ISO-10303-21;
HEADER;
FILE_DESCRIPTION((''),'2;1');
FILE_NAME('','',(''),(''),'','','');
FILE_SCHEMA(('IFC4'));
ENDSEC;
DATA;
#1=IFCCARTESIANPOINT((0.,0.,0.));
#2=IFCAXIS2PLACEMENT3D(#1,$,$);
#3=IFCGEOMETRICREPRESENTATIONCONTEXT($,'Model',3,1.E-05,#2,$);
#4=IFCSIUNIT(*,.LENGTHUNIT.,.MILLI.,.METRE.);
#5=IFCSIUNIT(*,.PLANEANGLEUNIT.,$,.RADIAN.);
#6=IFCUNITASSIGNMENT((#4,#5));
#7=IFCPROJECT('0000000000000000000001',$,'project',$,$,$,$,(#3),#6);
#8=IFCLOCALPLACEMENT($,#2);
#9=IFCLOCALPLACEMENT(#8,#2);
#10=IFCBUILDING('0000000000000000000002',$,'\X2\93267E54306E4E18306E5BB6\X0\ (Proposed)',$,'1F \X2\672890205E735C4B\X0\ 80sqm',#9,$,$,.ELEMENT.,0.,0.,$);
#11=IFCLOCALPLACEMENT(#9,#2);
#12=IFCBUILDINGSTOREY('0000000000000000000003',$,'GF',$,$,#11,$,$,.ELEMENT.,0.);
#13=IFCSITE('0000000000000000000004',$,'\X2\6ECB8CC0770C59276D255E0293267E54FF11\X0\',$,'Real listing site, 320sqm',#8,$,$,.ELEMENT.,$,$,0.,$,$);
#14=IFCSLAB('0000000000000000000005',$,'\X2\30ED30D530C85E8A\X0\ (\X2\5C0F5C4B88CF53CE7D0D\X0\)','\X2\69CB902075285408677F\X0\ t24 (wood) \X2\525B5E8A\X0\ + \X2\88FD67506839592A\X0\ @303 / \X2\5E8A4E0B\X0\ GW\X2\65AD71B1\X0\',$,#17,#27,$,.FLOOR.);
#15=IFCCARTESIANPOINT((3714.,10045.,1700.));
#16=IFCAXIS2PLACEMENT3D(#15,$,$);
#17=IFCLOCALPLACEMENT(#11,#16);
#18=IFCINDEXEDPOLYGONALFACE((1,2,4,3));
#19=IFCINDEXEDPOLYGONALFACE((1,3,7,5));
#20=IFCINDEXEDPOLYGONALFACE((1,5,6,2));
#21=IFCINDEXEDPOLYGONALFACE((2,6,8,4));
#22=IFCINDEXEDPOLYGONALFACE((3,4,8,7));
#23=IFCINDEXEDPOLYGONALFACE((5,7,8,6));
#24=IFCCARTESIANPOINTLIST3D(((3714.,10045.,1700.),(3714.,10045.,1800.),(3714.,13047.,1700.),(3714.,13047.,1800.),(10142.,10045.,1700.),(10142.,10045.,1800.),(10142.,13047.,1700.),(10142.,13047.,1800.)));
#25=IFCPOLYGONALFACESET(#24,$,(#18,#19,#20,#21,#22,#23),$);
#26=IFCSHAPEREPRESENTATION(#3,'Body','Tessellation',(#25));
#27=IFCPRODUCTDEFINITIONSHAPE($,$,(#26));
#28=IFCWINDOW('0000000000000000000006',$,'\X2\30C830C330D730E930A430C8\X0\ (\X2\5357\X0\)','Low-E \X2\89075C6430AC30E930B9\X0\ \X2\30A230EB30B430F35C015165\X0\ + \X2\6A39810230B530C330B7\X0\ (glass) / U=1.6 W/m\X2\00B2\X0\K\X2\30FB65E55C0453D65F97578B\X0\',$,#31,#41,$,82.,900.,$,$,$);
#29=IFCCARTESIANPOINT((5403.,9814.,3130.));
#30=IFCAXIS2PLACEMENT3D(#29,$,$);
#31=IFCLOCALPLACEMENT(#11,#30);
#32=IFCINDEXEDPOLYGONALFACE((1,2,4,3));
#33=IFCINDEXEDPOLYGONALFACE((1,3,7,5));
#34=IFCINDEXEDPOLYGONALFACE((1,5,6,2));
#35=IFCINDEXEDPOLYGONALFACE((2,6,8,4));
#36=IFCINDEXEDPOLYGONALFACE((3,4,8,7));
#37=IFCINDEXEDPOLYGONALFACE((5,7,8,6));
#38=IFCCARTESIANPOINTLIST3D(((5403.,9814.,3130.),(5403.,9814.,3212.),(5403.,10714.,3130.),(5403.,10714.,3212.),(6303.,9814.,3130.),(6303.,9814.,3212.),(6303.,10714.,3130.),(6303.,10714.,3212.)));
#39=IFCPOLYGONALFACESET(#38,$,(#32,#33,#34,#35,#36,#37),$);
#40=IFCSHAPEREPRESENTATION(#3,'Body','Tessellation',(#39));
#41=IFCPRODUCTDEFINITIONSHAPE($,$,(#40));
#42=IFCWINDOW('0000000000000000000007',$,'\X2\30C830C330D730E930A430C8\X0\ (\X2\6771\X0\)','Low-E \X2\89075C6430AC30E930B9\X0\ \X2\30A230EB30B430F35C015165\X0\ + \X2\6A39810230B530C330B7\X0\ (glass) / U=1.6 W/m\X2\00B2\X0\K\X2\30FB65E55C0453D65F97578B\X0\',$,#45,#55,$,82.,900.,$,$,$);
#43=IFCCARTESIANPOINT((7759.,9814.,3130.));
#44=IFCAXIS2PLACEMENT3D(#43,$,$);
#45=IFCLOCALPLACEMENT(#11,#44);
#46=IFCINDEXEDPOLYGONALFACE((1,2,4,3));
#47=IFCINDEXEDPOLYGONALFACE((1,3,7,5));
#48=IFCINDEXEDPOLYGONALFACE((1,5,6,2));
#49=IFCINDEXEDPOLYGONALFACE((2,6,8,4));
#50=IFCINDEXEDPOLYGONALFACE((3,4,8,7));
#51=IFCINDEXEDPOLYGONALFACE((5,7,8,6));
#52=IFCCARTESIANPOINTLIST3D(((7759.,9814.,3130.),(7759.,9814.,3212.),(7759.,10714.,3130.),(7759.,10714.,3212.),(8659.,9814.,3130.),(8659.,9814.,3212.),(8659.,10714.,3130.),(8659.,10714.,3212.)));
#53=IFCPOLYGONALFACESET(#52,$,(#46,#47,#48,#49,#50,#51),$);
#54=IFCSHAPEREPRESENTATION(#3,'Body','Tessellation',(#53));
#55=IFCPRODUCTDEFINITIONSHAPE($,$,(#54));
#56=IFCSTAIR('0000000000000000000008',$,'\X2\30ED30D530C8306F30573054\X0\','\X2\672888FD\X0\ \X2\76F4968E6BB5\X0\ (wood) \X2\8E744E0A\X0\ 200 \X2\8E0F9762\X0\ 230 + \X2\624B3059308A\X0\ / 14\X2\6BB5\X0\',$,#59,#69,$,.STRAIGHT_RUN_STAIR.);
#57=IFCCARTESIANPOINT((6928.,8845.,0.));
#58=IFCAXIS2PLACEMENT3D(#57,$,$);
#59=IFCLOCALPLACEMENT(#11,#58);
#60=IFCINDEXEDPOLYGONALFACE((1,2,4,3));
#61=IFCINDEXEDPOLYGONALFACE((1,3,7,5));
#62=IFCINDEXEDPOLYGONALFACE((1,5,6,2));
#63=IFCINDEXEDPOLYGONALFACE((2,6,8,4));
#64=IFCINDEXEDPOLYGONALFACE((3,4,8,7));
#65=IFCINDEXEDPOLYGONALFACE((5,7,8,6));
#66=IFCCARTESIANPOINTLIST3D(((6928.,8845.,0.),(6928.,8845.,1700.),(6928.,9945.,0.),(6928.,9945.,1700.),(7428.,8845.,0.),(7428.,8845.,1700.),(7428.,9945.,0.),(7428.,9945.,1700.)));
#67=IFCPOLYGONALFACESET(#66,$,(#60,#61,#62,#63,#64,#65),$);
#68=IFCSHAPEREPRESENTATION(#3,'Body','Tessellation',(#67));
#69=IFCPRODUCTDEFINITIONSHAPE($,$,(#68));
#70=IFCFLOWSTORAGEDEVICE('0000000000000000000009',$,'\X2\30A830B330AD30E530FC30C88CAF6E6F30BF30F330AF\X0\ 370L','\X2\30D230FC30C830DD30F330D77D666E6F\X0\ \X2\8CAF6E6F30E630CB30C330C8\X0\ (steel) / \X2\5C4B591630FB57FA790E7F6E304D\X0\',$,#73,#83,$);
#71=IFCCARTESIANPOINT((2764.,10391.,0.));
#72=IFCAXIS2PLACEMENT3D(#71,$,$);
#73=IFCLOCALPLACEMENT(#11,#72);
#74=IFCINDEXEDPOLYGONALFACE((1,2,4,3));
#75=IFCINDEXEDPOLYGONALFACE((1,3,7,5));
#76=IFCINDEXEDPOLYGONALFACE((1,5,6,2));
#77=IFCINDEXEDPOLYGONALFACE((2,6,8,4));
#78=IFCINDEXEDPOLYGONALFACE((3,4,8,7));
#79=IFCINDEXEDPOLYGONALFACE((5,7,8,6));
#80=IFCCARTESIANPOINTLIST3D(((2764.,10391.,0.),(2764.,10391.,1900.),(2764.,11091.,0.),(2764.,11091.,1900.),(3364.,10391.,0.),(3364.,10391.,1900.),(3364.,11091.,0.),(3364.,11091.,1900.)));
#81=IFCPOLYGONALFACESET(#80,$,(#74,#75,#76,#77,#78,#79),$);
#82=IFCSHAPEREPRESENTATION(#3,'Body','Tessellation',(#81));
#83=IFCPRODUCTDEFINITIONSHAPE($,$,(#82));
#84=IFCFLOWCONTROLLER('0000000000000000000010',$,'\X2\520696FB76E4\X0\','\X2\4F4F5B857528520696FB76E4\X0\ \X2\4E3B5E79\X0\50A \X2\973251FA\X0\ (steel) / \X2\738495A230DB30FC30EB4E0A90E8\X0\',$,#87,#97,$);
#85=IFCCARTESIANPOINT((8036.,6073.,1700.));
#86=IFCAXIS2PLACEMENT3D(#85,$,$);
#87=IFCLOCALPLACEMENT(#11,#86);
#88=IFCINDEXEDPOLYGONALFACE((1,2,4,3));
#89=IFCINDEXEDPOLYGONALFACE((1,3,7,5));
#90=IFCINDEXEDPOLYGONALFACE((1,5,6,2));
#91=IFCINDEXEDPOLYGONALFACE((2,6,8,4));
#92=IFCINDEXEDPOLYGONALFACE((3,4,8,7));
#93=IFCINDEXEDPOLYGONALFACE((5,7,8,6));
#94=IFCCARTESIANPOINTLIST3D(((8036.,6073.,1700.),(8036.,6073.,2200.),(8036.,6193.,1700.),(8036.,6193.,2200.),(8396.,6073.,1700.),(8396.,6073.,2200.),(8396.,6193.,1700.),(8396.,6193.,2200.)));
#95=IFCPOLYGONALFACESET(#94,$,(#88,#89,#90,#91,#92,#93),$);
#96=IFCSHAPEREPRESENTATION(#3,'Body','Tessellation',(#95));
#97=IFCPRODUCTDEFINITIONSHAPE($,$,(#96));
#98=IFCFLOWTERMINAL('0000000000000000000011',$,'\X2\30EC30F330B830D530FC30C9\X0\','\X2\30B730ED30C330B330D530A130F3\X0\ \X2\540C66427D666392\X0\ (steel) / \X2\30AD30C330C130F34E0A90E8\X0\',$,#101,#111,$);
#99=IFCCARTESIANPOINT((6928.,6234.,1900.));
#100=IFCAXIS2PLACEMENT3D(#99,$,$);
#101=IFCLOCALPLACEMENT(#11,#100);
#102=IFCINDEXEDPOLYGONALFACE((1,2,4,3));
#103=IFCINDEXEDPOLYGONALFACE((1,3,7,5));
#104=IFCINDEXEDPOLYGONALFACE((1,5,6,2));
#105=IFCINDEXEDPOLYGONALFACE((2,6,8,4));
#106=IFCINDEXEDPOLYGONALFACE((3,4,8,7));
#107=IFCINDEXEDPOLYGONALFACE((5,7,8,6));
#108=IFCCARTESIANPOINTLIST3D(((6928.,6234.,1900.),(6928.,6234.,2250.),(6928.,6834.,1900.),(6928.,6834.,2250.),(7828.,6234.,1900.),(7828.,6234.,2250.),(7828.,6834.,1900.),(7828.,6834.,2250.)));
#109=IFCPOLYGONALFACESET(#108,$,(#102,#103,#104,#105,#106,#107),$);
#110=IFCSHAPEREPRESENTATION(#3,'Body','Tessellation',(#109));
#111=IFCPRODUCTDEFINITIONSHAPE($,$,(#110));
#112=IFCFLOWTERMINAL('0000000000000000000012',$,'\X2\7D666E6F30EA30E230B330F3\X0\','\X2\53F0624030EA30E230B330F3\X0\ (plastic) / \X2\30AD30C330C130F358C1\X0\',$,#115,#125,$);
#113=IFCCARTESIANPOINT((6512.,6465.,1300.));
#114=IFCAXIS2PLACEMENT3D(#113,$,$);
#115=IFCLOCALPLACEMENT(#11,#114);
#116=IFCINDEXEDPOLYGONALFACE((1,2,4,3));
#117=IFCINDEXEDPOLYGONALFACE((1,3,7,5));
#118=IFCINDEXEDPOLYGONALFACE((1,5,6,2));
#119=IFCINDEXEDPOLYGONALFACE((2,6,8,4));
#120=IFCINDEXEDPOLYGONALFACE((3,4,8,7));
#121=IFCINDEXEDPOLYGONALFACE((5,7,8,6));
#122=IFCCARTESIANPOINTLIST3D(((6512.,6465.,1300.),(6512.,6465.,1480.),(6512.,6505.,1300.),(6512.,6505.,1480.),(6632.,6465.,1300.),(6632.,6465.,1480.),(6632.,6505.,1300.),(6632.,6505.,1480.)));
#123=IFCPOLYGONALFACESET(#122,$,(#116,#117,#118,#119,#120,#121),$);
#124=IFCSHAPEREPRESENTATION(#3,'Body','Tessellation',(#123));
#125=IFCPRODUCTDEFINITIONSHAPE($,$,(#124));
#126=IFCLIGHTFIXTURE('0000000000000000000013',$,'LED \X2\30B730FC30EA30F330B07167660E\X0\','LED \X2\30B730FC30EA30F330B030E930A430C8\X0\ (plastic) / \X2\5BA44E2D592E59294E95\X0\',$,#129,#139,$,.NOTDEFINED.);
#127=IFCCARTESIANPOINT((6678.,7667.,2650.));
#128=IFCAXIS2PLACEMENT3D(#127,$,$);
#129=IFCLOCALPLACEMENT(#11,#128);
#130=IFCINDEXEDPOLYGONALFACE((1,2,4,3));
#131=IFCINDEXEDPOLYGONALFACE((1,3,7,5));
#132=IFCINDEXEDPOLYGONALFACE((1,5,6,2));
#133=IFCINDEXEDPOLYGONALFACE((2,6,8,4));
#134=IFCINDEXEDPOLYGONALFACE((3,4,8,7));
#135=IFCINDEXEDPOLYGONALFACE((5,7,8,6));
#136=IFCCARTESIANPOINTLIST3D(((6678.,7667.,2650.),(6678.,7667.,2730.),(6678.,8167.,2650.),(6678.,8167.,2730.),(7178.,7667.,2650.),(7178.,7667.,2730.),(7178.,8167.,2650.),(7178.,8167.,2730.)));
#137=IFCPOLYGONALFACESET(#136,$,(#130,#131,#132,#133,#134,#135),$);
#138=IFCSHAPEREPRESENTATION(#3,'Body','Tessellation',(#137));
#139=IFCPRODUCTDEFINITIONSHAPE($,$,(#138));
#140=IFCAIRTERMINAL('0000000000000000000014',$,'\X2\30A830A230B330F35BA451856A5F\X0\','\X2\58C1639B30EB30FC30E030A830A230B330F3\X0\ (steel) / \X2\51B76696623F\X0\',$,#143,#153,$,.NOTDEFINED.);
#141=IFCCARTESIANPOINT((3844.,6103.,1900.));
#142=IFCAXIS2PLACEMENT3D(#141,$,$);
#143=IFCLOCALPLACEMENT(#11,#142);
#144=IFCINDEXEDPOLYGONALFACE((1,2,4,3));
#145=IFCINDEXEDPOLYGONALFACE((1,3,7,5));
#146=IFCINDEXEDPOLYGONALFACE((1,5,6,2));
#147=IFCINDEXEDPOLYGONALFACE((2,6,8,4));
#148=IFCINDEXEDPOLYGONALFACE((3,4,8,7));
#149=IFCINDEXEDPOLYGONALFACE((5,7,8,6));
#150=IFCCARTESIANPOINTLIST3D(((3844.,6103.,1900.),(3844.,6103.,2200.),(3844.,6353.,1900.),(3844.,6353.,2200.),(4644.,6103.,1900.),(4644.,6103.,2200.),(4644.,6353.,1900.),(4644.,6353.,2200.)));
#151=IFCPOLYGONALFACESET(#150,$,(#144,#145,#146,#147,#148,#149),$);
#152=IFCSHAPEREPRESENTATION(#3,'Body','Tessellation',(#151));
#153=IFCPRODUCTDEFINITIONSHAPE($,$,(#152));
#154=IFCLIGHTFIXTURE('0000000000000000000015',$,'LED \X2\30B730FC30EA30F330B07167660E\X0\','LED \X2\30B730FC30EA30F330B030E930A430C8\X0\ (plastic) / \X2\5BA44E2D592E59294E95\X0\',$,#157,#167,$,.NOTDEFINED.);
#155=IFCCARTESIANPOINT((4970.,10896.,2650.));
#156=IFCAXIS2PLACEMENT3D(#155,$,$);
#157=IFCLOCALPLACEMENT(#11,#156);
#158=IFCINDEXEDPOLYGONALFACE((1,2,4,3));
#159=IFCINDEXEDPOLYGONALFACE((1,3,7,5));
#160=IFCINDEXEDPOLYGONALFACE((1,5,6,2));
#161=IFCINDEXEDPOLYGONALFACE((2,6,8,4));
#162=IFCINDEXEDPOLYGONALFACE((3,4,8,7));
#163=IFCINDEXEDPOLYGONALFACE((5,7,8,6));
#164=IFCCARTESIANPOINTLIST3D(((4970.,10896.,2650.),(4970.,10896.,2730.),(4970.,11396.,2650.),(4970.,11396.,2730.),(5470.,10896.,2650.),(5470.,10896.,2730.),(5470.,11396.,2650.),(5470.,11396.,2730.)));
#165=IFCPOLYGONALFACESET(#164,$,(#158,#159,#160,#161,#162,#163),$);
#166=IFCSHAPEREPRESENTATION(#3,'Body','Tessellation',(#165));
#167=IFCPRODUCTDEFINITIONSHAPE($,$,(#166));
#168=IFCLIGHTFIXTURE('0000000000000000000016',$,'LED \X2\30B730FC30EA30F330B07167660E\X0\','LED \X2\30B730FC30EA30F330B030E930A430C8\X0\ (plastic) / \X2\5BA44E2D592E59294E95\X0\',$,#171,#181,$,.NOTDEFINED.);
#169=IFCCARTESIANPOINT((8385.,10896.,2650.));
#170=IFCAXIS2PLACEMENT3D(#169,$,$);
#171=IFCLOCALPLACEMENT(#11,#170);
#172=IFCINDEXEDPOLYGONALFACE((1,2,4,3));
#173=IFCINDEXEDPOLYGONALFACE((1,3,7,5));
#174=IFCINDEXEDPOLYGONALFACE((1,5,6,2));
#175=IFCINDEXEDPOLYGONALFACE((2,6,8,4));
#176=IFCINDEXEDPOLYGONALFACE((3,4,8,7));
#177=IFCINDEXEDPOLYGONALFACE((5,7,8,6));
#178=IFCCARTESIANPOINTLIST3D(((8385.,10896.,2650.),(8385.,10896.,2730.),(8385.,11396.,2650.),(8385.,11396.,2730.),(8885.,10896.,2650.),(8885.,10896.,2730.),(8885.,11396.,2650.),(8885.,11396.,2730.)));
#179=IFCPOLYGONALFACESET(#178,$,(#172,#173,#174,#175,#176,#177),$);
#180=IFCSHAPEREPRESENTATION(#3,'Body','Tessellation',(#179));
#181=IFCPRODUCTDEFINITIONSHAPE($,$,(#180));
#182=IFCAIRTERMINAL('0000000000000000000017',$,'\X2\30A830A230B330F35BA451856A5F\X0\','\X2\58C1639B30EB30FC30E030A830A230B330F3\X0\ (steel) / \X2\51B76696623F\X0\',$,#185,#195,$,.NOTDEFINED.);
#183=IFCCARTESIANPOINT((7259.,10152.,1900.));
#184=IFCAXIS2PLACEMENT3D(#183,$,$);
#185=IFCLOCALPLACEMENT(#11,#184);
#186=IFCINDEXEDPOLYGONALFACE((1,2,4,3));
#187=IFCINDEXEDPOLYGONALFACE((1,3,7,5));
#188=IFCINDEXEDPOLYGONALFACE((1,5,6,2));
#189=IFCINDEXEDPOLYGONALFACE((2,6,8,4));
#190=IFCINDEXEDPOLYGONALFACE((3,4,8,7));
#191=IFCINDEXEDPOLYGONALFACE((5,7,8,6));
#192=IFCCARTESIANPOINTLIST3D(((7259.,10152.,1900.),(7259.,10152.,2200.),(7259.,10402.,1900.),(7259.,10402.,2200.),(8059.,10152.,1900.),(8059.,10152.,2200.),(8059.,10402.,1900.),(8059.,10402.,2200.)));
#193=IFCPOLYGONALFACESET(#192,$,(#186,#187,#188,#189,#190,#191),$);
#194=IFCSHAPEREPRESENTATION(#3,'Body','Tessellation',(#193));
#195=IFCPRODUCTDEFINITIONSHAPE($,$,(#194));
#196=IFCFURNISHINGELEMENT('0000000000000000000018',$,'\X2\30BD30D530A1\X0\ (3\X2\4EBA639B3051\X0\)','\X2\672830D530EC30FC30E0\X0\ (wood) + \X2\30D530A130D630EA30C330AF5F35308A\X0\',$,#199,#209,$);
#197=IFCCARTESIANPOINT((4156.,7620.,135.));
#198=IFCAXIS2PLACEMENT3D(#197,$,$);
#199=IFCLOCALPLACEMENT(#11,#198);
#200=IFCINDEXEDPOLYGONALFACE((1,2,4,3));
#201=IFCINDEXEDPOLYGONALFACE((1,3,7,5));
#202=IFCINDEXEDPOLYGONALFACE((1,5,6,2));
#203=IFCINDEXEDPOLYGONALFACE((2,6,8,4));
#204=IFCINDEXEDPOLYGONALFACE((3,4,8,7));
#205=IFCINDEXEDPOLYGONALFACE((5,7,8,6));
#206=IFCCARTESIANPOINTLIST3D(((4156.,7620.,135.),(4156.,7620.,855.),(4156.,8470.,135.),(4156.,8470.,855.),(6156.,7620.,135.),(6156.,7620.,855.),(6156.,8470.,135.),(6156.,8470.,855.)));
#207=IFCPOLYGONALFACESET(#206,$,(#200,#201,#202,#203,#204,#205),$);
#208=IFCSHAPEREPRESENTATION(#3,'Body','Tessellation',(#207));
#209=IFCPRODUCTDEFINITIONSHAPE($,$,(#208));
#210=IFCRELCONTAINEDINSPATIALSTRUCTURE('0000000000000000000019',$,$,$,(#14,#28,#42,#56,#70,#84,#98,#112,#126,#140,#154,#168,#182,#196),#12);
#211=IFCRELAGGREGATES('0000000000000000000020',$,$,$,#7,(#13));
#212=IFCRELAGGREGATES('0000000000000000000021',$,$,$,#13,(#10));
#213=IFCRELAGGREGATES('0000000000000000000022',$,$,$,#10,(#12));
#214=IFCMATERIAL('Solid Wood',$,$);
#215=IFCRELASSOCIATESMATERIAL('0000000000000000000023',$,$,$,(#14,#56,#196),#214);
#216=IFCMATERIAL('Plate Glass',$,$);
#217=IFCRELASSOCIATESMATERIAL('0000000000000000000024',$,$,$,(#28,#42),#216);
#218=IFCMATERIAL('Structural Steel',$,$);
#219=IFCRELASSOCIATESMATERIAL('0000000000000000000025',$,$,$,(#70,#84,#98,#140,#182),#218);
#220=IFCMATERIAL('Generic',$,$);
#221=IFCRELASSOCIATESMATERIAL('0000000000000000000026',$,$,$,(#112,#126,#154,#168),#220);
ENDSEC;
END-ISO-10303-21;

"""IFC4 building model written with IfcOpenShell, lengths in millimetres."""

from ifc_helpers import new_model, si_unit, frame, frame_2d, origin, place, context, project, spatial, rectangle, extrude, material, element, save


model = new_model("IFC4")

# Units and contexts
model_context = context("Model", 3, precision=1e-05, world=origin())
ifc_project = project(units=[si_unit("LENGTHUNIT", "METRE", prefix="MILLI"), si_unit("PLANEANGLEUNIT", "RADIAN")], contexts=[model_context])

# Site, building, storey
site_placement = place(None, origin())
site = spatial("IfcSite", under=ifc_project, at=site_placement, Name="滋賀県大津市錦織１", ObjectType="Real listing site, 320sqm", CompositionType="ELEMENT", RefElevation=0.0)
building_placement = place(site_placement, origin())
building = spatial("IfcBuilding", under=site, at=building_placement, Name="錦織の丘の家 (Proposed)", ObjectType="1F 木造平屋 80sqm", CompositionType="ELEMENT", ElevationOfRefHeight=0.0, ElevationOfTerrain=0.0)
storey_placement = place(building_placement, origin())
storey = spatial("IfcBuildingStorey", under=building, at=storey_placement, Name="GF", CompositionType="ELEMENT", Elevation=0.0)

# Shared definitions
ifc_material_1 = material(Name="Solid Wood")

# Slab
slab_placement = place(storey_placement, frame((3714.0, 10045.0, 1700.0)))
element("IfcSlab", 1, at=slab_placement, inside=storey, material=ifc_material_1, Name="ロフト床 (小屋裏収納)", Description="構造用合板 t24 (wood) 剛床 + 製材根太 @303 / 床下 GW断熱", PredefinedType="FLOOR", context=model_context, shape_type="SweptSolid", body=[
    extrude(rectangle(XDim=6428.0, YDim=3002.0, at=frame_2d((3214.0, 1501.0))), frame((3714.0, 10045.0, 1700.0)), (0.0, 0.0, 1.0), 100.0),
])

# Windows
ifc_material_2 = material(Name="Plate Glass")
window_1_placement = place(storey_placement, frame((5403.0, 9814.0, 3130.0)))
element("IfcWindow", 2, at=window_1_placement, inside=storey, material=ifc_material_2, Name="トップライト (南)", Description="Low-E 複層ガラス アルゴン封入 + 樹脂サッシ (glass) / U=1.6 W/m²K・日射取得型", OverallHeight=82.0, OverallWidth=900.0, context=model_context, shape_type="SweptSolid", body=[
    extrude(rectangle(XDim=900.0, YDim=900.0, at=frame_2d((450.0, 450.0))), frame((5403.0, 9814.0, 3130.0)), (0.0, 0.0, 1.0), 82.0),
])
window_2_placement = place(storey_placement, frame((7759.0, 9814.0, 3130.0)))
element("IfcWindow", 3, at=window_2_placement, inside=storey, material=ifc_material_2, Name="トップライト (東)", Description="Low-E 複層ガラス アルゴン封入 + 樹脂サッシ (glass) / U=1.6 W/m²K・日射取得型", OverallHeight=82.0, OverallWidth=900.0, context=model_context, shape_type="SweptSolid", body=[
    extrude(rectangle(XDim=900.0, YDim=900.0, at=frame_2d((450.0, 450.0))), frame((7759.0, 9814.0, 3130.0)), (0.0, 0.0, 1.0), 82.0),
])

# Stair
stair_placement = place(storey_placement, frame((6928.0, 8845.0, 0.0)))
element("IfcStair", 4, at=stair_placement, inside=storey, material=ifc_material_1, Name="ロフトはしご", Description="木製 直階段 (wood) 蹴上 200 踏面 230 + 手すり / 14段", PredefinedType="STRAIGHT_RUN_STAIR", context=model_context, shape_type="SweptSolid", body=[
    extrude(rectangle(XDim=500.0, YDim=1100.0, at=frame_2d((250.0, 550.0))), frame((6928.0, 8845.0, 0.0)), (0.0, 0.0, 1.0), 1700.0),
])

# Flow storage device
ifc_material_3 = material(Name="Structural Steel")
flow_storage_device_placement = place(storey_placement, frame((2764.0, 10391.0, 0.0)))
element("IfcFlowStorageDevice", 5, at=flow_storage_device_placement, inside=storey, material=ifc_material_3, Name="エコキュート貯湯タンク 370L", Description="ヒートポンプ給湯 貯湯ユニット (steel) / 屋外・基礎置き", context=model_context, shape_type="SweptSolid", body=[
    extrude(rectangle(XDim=600.0, YDim=700.0, at=frame_2d((300.0, 350.0))), frame((2764.0, 10391.0, 0.0)), (0.0, 0.0, 1.0), 1900.0),
])

# Flow controller
flow_controller_placement = place(storey_placement, frame((8036.0, 6073.0, 1700.0)))
element("IfcFlowController", 6, at=flow_controller_placement, inside=storey, material=ifc_material_3, Name="分電盤", Description="住宅用分電盤 主幹50A 露出 (steel) / 玄関ホール上部", context=model_context, shape_type="SweptSolid", body=[
    extrude(rectangle(XDim=360.0, YDim=120.0, at=frame_2d((180.0, 60.0))), frame((8036.0, 6073.0, 1700.0)), (0.0, 0.0, 1.0), 500.0),
])

# Flow terminals
flow_terminal_1_placement = place(storey_placement, frame((6928.0, 6234.0, 1900.0)))
element("IfcFlowTerminal", 7, at=flow_terminal_1_placement, inside=storey, material=ifc_material_3, Name="レンジフード", Description="シロッコファン 同時給排 (steel) / キッチン上部", context=model_context, shape_type="SweptSolid", body=[
    extrude(rectangle(XDim=900.0, YDim=600.0, at=frame_2d((450.0, 300.0))), frame((6928.0, 6234.0, 1900.0)), (0.0, 0.0, 1.0), 350.0),
])
ifc_material_4 = material(Name="Generic")
flow_terminal_2_placement = place(storey_placement, frame((6512.0, 6465.0, 1300.0)))
element("IfcFlowTerminal", 8, at=flow_terminal_2_placement, inside=storey, material=ifc_material_4, Name="給湯リモコン", Description="台所リモコン (plastic) / キッチン壁", context=model_context, shape_type="SweptSolid", body=[
    extrude(rectangle(XDim=120.0, YDim=40.0, at=frame_2d((60.0, 20.0))), frame((6512.0, 6465.0, 1300.0)), (0.0, 0.0, 1.0), 180.0),
])

# Light fixture
light_fixture_1_placement = place(storey_placement, frame((6678.0, 7667.0, 2650.0)))
element("IfcLightFixture", 9, at=light_fixture_1_placement, inside=storey, material=ifc_material_4, Name="LED シーリング照明", Description="LED シーリングライト (plastic) / 室中央天井", PredefinedType="NOTDEFINED", context=model_context, shape_type="SweptSolid", body=[
    extrude(rectangle(XDim=500.0, YDim=500.0, at=frame_2d((250.0, 250.0))), frame((6678.0, 7667.0, 2650.0)), (0.0, 0.0, 1.0), 80.0),
])

# Air terminal
air_terminal_1_placement = place(storey_placement, frame((3844.0, 6103.0, 1900.0)))
element("IfcAirTerminal", 10, at=air_terminal_1_placement, inside=storey, material=ifc_material_3, Name="エアコン室内機", Description="壁掛ルームエアコン (steel) / 冷暖房", PredefinedType="NOTDEFINED", context=model_context, shape_type="SweptSolid", body=[
    extrude(rectangle(XDim=800.0, YDim=250.0, at=frame_2d((400.0, 125.0))), frame((3844.0, 6103.0, 1900.0)), (0.0, 0.0, 1.0), 300.0),
])

# Light fixtures
light_fixture_2_placement = place(storey_placement, frame((4970.0, 10896.0, 2650.0)))
element("IfcLightFixture", 11, at=light_fixture_2_placement, inside=storey, material=ifc_material_4, Name="LED シーリング照明", Description="LED シーリングライト (plastic) / 室中央天井", PredefinedType="NOTDEFINED", context=model_context, shape_type="SweptSolid", body=[
    extrude(rectangle(XDim=500.0, YDim=500.0, at=frame_2d((250.0, 250.0))), frame((4970.0, 10896.0, 2650.0)), (0.0, 0.0, 1.0), 80.0),
])
light_fixture_3_placement = place(storey_placement, frame((8385.0, 10896.0, 2650.0)))
element("IfcLightFixture", 12, at=light_fixture_3_placement, inside=storey, material=ifc_material_4, Name="LED シーリング照明", Description="LED シーリングライト (plastic) / 室中央天井", PredefinedType="NOTDEFINED", context=model_context, shape_type="SweptSolid", body=[
    extrude(rectangle(XDim=500.0, YDim=500.0, at=frame_2d((250.0, 250.0))), frame((8385.0, 10896.0, 2650.0)), (0.0, 0.0, 1.0), 80.0),
])

# Air terminal
air_terminal_2_placement = place(storey_placement, frame((7259.0, 10152.0, 1900.0)))
element("IfcAirTerminal", 13, at=air_terminal_2_placement, inside=storey, material=ifc_material_3, Name="エアコン室内機", Description="壁掛ルームエアコン (steel) / 冷暖房", PredefinedType="NOTDEFINED", context=model_context, shape_type="SweptSolid", body=[
    extrude(rectangle(XDim=800.0, YDim=250.0, at=frame_2d((400.0, 125.0))), frame((7259.0, 10152.0, 1900.0)), (0.0, 0.0, 1.0), 300.0),
])

# Furnishing element
furnishing_1_placement = place(storey_placement, frame((4156.0, 7620.0, 135.0)))
element("IfcFurnishingElement", 14, at=furnishing_1_placement, inside=storey, material=ifc_material_1, Name="ソファ (3人掛け)", Description="木フレーム (wood) + ファブリック張り", context=model_context, shape_type="SweptSolid", body=[
    extrude(rectangle(XDim=2000.0, YDim=850.0, at=frame_2d((1000.0, 425.0))), frame((4156.0, 7620.0, 135.0)), (0.0, 0.0, 1.0), 720.0),
])

save(model, "model.ifc")
